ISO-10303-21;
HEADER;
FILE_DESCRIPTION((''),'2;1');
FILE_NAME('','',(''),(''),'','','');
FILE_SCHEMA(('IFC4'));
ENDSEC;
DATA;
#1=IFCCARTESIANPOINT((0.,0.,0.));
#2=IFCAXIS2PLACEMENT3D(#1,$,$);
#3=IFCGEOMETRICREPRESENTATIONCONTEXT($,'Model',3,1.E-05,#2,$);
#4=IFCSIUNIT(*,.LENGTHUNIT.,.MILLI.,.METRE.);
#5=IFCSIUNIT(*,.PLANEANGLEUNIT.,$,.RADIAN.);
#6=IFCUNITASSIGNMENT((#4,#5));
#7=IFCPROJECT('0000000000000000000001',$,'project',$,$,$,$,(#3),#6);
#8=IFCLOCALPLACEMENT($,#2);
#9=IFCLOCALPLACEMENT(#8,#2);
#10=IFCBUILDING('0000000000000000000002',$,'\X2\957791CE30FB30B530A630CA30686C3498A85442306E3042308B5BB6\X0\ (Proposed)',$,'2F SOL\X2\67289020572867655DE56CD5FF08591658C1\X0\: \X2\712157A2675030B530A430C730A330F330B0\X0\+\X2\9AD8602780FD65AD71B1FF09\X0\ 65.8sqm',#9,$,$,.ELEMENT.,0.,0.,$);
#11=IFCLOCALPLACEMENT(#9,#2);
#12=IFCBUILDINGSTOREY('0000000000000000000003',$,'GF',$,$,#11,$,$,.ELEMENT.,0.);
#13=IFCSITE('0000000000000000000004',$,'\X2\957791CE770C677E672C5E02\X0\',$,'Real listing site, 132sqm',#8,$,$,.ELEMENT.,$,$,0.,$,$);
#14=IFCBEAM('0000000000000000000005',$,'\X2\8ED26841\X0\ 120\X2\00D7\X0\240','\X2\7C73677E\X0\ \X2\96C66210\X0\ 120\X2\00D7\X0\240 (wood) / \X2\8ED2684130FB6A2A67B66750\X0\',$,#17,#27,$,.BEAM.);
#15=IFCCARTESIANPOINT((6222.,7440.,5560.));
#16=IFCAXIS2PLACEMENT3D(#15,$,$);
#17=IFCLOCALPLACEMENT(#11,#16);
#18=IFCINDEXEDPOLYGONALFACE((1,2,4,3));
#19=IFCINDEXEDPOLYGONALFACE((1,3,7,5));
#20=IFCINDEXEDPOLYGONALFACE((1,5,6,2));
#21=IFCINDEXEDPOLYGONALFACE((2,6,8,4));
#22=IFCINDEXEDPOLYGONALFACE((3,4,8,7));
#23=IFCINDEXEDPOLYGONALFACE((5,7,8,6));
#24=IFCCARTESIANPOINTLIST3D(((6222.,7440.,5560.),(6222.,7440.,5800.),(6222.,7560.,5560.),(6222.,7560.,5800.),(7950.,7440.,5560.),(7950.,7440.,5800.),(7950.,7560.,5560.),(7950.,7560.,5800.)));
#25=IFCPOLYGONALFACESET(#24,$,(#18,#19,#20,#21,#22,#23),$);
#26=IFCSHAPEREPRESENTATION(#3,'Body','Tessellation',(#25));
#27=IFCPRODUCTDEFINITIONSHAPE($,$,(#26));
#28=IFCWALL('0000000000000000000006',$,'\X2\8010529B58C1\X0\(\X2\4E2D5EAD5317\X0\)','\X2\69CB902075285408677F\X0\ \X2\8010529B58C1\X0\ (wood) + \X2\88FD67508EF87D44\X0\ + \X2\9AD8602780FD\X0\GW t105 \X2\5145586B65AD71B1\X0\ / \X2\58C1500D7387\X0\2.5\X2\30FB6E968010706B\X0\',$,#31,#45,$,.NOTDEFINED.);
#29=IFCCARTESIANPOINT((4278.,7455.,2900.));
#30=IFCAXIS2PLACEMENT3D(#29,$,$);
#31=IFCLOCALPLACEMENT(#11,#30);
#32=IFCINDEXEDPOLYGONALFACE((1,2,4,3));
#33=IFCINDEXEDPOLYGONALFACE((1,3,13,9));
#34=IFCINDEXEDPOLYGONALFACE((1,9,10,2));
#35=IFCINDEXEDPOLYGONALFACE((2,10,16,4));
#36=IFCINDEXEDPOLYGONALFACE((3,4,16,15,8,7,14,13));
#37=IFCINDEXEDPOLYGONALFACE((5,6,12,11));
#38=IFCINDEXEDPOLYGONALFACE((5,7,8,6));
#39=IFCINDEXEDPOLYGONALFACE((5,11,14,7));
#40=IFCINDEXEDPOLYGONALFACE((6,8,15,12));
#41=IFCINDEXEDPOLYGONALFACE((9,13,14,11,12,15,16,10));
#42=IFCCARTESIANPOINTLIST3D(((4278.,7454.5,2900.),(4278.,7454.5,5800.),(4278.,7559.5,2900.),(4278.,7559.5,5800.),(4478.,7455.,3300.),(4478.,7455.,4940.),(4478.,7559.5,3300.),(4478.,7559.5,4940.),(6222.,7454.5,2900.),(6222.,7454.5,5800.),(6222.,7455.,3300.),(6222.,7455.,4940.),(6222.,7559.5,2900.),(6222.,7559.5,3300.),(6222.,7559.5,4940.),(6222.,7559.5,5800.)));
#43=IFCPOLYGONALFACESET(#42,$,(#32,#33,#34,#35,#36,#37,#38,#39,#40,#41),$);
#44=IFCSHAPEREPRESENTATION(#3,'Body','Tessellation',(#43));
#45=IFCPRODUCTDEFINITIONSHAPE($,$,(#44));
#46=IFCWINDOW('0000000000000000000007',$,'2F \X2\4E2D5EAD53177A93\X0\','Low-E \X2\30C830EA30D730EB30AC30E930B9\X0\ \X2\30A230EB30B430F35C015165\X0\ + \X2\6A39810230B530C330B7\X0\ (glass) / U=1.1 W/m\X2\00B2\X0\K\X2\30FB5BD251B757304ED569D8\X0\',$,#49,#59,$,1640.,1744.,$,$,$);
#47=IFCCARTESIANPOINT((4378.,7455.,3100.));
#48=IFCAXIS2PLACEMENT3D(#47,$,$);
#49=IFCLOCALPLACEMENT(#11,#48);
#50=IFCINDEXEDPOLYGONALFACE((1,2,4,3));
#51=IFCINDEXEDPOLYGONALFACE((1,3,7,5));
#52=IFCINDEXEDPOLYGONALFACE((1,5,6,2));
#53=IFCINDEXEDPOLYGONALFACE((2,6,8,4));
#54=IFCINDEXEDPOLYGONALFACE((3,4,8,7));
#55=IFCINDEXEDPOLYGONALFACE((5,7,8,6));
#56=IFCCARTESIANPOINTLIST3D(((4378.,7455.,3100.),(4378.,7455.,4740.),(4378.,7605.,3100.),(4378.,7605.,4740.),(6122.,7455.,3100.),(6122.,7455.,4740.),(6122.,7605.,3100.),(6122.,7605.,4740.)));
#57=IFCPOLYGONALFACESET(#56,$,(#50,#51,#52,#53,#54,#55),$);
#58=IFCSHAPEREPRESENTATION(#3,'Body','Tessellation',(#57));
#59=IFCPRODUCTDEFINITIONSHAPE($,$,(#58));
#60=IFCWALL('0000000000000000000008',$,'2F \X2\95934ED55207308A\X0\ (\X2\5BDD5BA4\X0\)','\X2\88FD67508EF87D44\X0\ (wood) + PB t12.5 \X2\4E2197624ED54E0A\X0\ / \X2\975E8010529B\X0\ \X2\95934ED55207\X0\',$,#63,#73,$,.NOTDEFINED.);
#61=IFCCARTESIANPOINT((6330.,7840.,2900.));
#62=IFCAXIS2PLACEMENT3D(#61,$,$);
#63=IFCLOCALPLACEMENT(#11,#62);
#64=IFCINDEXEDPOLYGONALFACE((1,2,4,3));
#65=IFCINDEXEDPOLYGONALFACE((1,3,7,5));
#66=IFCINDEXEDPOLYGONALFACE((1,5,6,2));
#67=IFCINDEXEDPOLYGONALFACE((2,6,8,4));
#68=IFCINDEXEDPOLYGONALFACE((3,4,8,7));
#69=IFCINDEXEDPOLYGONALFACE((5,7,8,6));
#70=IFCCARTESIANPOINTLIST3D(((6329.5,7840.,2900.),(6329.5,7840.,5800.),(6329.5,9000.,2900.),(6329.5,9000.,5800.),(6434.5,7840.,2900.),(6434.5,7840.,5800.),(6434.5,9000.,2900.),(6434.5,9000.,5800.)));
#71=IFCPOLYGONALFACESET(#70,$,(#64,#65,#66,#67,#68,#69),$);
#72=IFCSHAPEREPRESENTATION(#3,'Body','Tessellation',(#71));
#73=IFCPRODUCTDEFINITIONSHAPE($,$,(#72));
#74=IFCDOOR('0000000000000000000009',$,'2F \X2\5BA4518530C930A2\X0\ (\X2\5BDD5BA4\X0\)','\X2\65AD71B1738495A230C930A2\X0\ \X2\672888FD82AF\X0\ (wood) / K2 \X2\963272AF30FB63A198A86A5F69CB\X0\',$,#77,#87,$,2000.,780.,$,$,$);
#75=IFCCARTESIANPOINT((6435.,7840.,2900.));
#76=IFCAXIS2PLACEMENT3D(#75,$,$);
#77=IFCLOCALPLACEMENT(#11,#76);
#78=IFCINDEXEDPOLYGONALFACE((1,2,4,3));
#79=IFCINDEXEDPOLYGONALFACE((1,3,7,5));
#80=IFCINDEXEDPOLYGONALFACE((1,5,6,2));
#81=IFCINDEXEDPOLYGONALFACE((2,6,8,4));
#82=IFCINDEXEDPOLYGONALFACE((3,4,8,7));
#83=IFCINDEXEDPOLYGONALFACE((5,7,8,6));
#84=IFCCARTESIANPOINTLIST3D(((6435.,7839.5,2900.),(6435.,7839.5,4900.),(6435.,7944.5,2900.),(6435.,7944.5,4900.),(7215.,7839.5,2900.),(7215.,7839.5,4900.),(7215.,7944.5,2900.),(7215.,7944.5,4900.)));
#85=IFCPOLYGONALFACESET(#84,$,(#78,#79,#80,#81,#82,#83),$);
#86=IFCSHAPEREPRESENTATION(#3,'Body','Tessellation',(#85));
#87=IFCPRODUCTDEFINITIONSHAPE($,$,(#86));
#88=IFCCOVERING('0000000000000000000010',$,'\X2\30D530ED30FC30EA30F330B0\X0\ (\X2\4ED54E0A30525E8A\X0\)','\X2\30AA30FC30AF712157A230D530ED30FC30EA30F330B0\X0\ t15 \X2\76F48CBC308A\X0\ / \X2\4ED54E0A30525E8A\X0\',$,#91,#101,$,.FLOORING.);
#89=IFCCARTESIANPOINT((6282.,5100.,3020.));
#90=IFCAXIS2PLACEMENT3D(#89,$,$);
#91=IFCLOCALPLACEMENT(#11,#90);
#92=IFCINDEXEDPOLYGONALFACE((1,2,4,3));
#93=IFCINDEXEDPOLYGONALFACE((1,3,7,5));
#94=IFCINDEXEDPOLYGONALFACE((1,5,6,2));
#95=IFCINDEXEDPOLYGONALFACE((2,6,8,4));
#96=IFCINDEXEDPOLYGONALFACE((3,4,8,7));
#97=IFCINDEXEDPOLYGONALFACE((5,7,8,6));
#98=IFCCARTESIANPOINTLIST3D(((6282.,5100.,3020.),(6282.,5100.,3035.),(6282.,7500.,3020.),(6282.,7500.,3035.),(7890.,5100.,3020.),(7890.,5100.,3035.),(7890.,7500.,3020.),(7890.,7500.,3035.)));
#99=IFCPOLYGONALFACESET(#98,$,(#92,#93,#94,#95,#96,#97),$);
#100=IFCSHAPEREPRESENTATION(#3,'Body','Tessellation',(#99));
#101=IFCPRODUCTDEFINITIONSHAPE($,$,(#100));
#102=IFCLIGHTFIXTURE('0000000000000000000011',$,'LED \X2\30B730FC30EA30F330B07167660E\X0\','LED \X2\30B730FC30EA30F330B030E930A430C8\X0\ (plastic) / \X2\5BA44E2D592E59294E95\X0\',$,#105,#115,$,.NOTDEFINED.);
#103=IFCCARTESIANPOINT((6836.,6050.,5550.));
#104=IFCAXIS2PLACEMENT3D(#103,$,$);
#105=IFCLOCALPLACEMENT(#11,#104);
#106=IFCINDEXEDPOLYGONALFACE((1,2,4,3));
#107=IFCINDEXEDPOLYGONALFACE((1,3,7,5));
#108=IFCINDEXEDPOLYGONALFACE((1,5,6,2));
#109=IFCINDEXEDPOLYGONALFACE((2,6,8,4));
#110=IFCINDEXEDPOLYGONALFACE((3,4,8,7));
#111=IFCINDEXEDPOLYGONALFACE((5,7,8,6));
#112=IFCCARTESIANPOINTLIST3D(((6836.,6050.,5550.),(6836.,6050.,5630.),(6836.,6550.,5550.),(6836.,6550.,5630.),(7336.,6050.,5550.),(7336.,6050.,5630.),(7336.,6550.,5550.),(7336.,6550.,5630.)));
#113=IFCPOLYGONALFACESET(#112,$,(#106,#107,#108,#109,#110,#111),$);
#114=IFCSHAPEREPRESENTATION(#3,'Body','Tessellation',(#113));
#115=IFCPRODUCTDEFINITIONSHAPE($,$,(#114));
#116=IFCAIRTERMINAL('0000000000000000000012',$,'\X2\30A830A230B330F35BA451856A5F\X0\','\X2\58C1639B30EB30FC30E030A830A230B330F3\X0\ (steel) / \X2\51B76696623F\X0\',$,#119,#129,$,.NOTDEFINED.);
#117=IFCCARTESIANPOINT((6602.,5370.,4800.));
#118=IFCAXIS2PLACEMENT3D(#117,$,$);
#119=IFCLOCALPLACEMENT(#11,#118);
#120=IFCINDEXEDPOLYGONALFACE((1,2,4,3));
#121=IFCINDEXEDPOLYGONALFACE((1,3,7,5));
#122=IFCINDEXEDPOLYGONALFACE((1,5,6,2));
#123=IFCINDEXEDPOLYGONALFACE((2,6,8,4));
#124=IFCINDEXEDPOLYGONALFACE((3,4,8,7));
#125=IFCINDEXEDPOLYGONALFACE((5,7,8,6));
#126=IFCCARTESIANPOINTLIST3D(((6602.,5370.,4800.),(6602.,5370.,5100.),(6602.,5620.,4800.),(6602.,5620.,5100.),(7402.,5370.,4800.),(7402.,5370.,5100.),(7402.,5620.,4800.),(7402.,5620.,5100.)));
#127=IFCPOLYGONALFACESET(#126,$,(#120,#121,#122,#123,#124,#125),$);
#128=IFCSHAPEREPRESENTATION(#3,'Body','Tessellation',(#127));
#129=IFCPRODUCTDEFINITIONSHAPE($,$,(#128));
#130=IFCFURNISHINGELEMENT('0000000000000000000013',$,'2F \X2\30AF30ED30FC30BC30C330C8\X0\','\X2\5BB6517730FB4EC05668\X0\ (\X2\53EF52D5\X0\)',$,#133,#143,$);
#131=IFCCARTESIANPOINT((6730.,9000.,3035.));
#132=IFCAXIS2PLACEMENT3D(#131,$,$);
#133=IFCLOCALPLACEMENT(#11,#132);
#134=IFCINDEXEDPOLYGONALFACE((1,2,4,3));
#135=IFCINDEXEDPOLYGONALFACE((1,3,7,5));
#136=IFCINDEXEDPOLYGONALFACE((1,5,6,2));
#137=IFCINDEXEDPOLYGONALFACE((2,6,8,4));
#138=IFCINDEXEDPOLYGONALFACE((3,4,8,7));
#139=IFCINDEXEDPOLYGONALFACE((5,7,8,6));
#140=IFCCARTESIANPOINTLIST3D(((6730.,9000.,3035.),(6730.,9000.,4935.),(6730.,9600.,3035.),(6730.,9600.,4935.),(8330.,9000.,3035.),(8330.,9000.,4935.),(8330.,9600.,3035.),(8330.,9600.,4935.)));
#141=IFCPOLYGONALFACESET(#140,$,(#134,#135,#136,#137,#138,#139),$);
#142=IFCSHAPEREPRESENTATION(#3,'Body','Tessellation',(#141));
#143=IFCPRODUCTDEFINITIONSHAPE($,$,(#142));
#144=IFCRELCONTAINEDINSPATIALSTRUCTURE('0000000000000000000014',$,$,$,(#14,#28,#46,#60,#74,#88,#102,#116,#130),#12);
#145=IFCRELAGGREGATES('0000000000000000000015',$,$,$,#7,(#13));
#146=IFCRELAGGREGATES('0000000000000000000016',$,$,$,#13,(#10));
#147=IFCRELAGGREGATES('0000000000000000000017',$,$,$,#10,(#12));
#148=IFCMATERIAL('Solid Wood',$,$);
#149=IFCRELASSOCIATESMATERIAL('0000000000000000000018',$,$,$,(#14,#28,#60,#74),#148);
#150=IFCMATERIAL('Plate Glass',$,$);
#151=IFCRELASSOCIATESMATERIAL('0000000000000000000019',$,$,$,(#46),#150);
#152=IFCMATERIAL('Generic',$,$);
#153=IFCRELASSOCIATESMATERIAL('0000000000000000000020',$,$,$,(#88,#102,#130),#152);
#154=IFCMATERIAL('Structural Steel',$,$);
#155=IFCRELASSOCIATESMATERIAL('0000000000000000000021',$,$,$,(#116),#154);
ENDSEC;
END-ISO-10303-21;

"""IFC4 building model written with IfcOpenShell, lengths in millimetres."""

from ifc_helpers import new_model, si_unit, frame, frame_2d, origin, place, context, project, spatial, rectangle, extrude, material, element, fill, save


model = new_model("IFC4")

# Units and contexts
model_context = context("Model", 3, precision=1e-05, world=origin())
ifc_project = project(units=[si_unit("LENGTHUNIT", "METRE", prefix="MILLI"), si_unit("PLANEANGLEUNIT", "RADIAN")], contexts=[model_context])

# Site, building, storey
site_placement = place(None, origin())
site = spatial("IfcSite", under=ifc_project, at=site_placement, Name="長野県松本市", ObjectType="Real listing site, 132sqm", CompositionType="ELEMENT", RefElevation=0.0)
building_placement = place(site_placement, origin())
building = spatial("IfcBuilding", under=site, at=building_placement, Name="長野・サウナと水風呂のある家 (Proposed)", ObjectType="2F SOL木造在来工法（外壁: 無垢材サイディング+高性能断熱） 65.8sqm", CompositionType="ELEMENT", ElevationOfRefHeight=0.0, ElevationOfTerrain=0.0)
storey_placement = place(building_placement, origin())
storey = spatial("IfcBuildingStorey", under=building, at=storey_placement, Name="GF", CompositionType="ELEMENT", Elevation=0.0)

# Shared definitions
ifc_material_1 = material(Name="Solid Wood")

# Beam
beam_1_placement = place(storey_placement, frame((6222.0, 7440.0, 5560.0)))
element("IfcBeam", 1, at=beam_1_placement, inside=storey, material=ifc_material_1, Name="軒桁 120×240", Description="米松 集成 120×240 (wood) / 軒桁・横架材", PredefinedType="BEAM", context=model_context, shape_type="SweptSolid", body=[
    extrude(rectangle(XDim=1728.0, YDim=120.0, at=frame_2d((864.0, 60.0))), frame((6222.0, 7440.0, 5560.0)), (0.0, 0.0, 1.0), 240.0),
])

# Wall, opening, window
wall_1_placement = place(storey_placement, frame((4278.0, 7455.0, 2900.0)))
wall_1 = element("IfcWall", 2, at=wall_1_placement, inside=storey, material=ifc_material_1, Name="耐力壁(中庭北)", Description="構造用合板 耐力壁 (wood) + 製材軸組 + 高性能GW t105 充填断熱 / 壁倍率2.5・準耐火", PredefinedType="NOTDEFINED", context=model_context, shape_type="SweptSolid", body=[
    extrude(rectangle(XDim=1944.0, YDim=105.0, at=frame_2d((972.0, 52.0))), frame((4278.0, 7455.0, 2900.0)), (0.0, 0.0, 1.0), 2900.0),
])
opening_placement = place(storey_placement, frame((4378.0, 7455.0, 3100.0)))
opening = element("IfcOpeningElement", 3, at=opening_placement, cuts=wall_1, PredefinedType="NOTDEFINED", context=model_context, shape_type="SweptSolid", body=[
    extrude(rectangle(XDim=1744.0, YDim=150.0, at=frame_2d((872.0, 75.0))), frame((4378.0, 7455.0, 3100.0)), (0.0, 0.0, 1.0), 1640.0),
])
ifc_material_2 = material(Name="Plate Glass")
window_placement = place(storey_placement, frame((4378.0, 7455.0, 3100.0)))
window = element("IfcWindow", 4, at=window_placement, inside=storey, material=ifc_material_2, Name="2F 中庭北窓", Description="Low-E トリプルガラス アルゴン封入 + 樹脂サッシ (glass) / U=1.1 W/m²K・寒冷地仕様", OverallHeight=1640.0, OverallWidth=1744.0, context=model_context, shape_type="SweptSolid", body=[
    extrude(rectangle(XDim=1744.0, YDim=150.0, at=frame_2d((872.0, 75.0))), frame((4378.0, 7455.0, 3100.0)), (0.0, 0.0, 1.0), 1640.0),
])
fill(opening, window)

# Wall
wall_2_placement = place(storey_placement, frame((6330.0, 7840.0, 2900.0)))
element("IfcWall", 5, at=wall_2_placement, inside=storey, material=ifc_material_1, Name="2F 間仕切り (寝室)", Description="製材軸組 (wood) + PB t12.5 両面仕上 / 非耐力 間仕切", PredefinedType="NOTDEFINED", context=model_context, shape_type="SweptSolid", body=[
    extrude(rectangle(XDim=105.0, YDim=1160.0, at=frame_2d((52.0, 580.0))), frame((6330.0, 7840.0, 2900.0)), (0.0, 0.0, 1.0), 2900.0),
])

# Door
door_placement = place(storey_placement, frame((6435.0, 7840.0, 2900.0)))
element("IfcDoor", 6, at=door_placement, inside=storey, material=ifc_material_1, Name="2F 室内ドア (寝室)", Description="断熱玄関ドア 木製芯 (wood) / K2 防犯・採風機構", OverallHeight=2000.0, OverallWidth=780.0, context=model_context, shape_type="SweptSolid", body=[
    extrude(rectangle(XDim=780.0, YDim=105.0, at=frame_2d((390.0, 52.0))), frame((6435.0, 7840.0, 2900.0)), (0.0, 0.0, 1.0), 2000.0),
])

# Covering
ifc_material_3 = material(Name="Generic")
covering_placement = place(storey_placement, frame((6282.0, 5100.0, 3020.0)))
element("IfcCovering", 7, at=covering_placement, inside=storey, material=ifc_material_3, Name="フローリング (仕上げ床)", Description="オーク無垢フローリング t15 直貼り / 仕上げ床", PredefinedType="FLOORING", context=model_context, shape_type="SweptSolid", body=[
    extrude(rectangle(XDim=1608.0, YDim=2400.0, at=frame_2d((804.0, 1200.0))), frame((6282.0, 5100.0, 3020.0)), (0.0, 0.0, 1.0), 15.0),
])

# Light fixture
light_fixture_placement = place(storey_placement, frame((6836.0, 6050.0, 5550.0)))
element("IfcLightFixture", 8, at=light_fixture_placement, inside=storey, material=ifc_material_3, Name="LED シーリング照明", Description="LED シーリングライト (plastic) / 室中央天井", PredefinedType="NOTDEFINED", context=model_context, shape_type="SweptSolid", body=[
    extrude(rectangle(XDim=500.0, YDim=500.0, at=frame_2d((250.0, 250.0))), frame((6836.0, 6050.0, 5550.0)), (0.0, 0.0, 1.0), 80.0),
])

# Air terminal
ifc_material_4 = material(Name="Structural Steel")
air_terminal_placement = place(storey_placement, frame((6602.0, 5370.0, 4800.0)))
element("IfcAirTerminal", 9, at=air_terminal_placement, inside=storey, material=ifc_material_4, Name="エアコン室内機", Description="壁掛ルームエアコン (steel) / 冷暖房", PredefinedType="NOTDEFINED", context=model_context, shape_type="SweptSolid", body=[
    extrude(rectangle(XDim=800.0, YDim=250.0, at=frame_2d((400.0, 125.0))), frame((6602.0, 5370.0, 4800.0)), (0.0, 0.0, 1.0), 300.0),
])

# Furnishing element
furnishing_placement = place(storey_placement, frame((6730.0, 9000.0, 3035.0)))
element("IfcFurnishingElement", 10, at=furnishing_placement, inside=storey, material=ifc_material_3, Name="2F クローゼット", Description="家具・什器 (可動)", context=model_context, shape_type="SweptSolid", body=[
    extrude(rectangle(XDim=1600.0, YDim=600.0, at=frame_2d((800.0, 300.0))), frame((6730.0, 9000.0, 3035.0)), (0.0, 0.0, 1.0), 1900.0),
])

save(model, "model.ifc")
